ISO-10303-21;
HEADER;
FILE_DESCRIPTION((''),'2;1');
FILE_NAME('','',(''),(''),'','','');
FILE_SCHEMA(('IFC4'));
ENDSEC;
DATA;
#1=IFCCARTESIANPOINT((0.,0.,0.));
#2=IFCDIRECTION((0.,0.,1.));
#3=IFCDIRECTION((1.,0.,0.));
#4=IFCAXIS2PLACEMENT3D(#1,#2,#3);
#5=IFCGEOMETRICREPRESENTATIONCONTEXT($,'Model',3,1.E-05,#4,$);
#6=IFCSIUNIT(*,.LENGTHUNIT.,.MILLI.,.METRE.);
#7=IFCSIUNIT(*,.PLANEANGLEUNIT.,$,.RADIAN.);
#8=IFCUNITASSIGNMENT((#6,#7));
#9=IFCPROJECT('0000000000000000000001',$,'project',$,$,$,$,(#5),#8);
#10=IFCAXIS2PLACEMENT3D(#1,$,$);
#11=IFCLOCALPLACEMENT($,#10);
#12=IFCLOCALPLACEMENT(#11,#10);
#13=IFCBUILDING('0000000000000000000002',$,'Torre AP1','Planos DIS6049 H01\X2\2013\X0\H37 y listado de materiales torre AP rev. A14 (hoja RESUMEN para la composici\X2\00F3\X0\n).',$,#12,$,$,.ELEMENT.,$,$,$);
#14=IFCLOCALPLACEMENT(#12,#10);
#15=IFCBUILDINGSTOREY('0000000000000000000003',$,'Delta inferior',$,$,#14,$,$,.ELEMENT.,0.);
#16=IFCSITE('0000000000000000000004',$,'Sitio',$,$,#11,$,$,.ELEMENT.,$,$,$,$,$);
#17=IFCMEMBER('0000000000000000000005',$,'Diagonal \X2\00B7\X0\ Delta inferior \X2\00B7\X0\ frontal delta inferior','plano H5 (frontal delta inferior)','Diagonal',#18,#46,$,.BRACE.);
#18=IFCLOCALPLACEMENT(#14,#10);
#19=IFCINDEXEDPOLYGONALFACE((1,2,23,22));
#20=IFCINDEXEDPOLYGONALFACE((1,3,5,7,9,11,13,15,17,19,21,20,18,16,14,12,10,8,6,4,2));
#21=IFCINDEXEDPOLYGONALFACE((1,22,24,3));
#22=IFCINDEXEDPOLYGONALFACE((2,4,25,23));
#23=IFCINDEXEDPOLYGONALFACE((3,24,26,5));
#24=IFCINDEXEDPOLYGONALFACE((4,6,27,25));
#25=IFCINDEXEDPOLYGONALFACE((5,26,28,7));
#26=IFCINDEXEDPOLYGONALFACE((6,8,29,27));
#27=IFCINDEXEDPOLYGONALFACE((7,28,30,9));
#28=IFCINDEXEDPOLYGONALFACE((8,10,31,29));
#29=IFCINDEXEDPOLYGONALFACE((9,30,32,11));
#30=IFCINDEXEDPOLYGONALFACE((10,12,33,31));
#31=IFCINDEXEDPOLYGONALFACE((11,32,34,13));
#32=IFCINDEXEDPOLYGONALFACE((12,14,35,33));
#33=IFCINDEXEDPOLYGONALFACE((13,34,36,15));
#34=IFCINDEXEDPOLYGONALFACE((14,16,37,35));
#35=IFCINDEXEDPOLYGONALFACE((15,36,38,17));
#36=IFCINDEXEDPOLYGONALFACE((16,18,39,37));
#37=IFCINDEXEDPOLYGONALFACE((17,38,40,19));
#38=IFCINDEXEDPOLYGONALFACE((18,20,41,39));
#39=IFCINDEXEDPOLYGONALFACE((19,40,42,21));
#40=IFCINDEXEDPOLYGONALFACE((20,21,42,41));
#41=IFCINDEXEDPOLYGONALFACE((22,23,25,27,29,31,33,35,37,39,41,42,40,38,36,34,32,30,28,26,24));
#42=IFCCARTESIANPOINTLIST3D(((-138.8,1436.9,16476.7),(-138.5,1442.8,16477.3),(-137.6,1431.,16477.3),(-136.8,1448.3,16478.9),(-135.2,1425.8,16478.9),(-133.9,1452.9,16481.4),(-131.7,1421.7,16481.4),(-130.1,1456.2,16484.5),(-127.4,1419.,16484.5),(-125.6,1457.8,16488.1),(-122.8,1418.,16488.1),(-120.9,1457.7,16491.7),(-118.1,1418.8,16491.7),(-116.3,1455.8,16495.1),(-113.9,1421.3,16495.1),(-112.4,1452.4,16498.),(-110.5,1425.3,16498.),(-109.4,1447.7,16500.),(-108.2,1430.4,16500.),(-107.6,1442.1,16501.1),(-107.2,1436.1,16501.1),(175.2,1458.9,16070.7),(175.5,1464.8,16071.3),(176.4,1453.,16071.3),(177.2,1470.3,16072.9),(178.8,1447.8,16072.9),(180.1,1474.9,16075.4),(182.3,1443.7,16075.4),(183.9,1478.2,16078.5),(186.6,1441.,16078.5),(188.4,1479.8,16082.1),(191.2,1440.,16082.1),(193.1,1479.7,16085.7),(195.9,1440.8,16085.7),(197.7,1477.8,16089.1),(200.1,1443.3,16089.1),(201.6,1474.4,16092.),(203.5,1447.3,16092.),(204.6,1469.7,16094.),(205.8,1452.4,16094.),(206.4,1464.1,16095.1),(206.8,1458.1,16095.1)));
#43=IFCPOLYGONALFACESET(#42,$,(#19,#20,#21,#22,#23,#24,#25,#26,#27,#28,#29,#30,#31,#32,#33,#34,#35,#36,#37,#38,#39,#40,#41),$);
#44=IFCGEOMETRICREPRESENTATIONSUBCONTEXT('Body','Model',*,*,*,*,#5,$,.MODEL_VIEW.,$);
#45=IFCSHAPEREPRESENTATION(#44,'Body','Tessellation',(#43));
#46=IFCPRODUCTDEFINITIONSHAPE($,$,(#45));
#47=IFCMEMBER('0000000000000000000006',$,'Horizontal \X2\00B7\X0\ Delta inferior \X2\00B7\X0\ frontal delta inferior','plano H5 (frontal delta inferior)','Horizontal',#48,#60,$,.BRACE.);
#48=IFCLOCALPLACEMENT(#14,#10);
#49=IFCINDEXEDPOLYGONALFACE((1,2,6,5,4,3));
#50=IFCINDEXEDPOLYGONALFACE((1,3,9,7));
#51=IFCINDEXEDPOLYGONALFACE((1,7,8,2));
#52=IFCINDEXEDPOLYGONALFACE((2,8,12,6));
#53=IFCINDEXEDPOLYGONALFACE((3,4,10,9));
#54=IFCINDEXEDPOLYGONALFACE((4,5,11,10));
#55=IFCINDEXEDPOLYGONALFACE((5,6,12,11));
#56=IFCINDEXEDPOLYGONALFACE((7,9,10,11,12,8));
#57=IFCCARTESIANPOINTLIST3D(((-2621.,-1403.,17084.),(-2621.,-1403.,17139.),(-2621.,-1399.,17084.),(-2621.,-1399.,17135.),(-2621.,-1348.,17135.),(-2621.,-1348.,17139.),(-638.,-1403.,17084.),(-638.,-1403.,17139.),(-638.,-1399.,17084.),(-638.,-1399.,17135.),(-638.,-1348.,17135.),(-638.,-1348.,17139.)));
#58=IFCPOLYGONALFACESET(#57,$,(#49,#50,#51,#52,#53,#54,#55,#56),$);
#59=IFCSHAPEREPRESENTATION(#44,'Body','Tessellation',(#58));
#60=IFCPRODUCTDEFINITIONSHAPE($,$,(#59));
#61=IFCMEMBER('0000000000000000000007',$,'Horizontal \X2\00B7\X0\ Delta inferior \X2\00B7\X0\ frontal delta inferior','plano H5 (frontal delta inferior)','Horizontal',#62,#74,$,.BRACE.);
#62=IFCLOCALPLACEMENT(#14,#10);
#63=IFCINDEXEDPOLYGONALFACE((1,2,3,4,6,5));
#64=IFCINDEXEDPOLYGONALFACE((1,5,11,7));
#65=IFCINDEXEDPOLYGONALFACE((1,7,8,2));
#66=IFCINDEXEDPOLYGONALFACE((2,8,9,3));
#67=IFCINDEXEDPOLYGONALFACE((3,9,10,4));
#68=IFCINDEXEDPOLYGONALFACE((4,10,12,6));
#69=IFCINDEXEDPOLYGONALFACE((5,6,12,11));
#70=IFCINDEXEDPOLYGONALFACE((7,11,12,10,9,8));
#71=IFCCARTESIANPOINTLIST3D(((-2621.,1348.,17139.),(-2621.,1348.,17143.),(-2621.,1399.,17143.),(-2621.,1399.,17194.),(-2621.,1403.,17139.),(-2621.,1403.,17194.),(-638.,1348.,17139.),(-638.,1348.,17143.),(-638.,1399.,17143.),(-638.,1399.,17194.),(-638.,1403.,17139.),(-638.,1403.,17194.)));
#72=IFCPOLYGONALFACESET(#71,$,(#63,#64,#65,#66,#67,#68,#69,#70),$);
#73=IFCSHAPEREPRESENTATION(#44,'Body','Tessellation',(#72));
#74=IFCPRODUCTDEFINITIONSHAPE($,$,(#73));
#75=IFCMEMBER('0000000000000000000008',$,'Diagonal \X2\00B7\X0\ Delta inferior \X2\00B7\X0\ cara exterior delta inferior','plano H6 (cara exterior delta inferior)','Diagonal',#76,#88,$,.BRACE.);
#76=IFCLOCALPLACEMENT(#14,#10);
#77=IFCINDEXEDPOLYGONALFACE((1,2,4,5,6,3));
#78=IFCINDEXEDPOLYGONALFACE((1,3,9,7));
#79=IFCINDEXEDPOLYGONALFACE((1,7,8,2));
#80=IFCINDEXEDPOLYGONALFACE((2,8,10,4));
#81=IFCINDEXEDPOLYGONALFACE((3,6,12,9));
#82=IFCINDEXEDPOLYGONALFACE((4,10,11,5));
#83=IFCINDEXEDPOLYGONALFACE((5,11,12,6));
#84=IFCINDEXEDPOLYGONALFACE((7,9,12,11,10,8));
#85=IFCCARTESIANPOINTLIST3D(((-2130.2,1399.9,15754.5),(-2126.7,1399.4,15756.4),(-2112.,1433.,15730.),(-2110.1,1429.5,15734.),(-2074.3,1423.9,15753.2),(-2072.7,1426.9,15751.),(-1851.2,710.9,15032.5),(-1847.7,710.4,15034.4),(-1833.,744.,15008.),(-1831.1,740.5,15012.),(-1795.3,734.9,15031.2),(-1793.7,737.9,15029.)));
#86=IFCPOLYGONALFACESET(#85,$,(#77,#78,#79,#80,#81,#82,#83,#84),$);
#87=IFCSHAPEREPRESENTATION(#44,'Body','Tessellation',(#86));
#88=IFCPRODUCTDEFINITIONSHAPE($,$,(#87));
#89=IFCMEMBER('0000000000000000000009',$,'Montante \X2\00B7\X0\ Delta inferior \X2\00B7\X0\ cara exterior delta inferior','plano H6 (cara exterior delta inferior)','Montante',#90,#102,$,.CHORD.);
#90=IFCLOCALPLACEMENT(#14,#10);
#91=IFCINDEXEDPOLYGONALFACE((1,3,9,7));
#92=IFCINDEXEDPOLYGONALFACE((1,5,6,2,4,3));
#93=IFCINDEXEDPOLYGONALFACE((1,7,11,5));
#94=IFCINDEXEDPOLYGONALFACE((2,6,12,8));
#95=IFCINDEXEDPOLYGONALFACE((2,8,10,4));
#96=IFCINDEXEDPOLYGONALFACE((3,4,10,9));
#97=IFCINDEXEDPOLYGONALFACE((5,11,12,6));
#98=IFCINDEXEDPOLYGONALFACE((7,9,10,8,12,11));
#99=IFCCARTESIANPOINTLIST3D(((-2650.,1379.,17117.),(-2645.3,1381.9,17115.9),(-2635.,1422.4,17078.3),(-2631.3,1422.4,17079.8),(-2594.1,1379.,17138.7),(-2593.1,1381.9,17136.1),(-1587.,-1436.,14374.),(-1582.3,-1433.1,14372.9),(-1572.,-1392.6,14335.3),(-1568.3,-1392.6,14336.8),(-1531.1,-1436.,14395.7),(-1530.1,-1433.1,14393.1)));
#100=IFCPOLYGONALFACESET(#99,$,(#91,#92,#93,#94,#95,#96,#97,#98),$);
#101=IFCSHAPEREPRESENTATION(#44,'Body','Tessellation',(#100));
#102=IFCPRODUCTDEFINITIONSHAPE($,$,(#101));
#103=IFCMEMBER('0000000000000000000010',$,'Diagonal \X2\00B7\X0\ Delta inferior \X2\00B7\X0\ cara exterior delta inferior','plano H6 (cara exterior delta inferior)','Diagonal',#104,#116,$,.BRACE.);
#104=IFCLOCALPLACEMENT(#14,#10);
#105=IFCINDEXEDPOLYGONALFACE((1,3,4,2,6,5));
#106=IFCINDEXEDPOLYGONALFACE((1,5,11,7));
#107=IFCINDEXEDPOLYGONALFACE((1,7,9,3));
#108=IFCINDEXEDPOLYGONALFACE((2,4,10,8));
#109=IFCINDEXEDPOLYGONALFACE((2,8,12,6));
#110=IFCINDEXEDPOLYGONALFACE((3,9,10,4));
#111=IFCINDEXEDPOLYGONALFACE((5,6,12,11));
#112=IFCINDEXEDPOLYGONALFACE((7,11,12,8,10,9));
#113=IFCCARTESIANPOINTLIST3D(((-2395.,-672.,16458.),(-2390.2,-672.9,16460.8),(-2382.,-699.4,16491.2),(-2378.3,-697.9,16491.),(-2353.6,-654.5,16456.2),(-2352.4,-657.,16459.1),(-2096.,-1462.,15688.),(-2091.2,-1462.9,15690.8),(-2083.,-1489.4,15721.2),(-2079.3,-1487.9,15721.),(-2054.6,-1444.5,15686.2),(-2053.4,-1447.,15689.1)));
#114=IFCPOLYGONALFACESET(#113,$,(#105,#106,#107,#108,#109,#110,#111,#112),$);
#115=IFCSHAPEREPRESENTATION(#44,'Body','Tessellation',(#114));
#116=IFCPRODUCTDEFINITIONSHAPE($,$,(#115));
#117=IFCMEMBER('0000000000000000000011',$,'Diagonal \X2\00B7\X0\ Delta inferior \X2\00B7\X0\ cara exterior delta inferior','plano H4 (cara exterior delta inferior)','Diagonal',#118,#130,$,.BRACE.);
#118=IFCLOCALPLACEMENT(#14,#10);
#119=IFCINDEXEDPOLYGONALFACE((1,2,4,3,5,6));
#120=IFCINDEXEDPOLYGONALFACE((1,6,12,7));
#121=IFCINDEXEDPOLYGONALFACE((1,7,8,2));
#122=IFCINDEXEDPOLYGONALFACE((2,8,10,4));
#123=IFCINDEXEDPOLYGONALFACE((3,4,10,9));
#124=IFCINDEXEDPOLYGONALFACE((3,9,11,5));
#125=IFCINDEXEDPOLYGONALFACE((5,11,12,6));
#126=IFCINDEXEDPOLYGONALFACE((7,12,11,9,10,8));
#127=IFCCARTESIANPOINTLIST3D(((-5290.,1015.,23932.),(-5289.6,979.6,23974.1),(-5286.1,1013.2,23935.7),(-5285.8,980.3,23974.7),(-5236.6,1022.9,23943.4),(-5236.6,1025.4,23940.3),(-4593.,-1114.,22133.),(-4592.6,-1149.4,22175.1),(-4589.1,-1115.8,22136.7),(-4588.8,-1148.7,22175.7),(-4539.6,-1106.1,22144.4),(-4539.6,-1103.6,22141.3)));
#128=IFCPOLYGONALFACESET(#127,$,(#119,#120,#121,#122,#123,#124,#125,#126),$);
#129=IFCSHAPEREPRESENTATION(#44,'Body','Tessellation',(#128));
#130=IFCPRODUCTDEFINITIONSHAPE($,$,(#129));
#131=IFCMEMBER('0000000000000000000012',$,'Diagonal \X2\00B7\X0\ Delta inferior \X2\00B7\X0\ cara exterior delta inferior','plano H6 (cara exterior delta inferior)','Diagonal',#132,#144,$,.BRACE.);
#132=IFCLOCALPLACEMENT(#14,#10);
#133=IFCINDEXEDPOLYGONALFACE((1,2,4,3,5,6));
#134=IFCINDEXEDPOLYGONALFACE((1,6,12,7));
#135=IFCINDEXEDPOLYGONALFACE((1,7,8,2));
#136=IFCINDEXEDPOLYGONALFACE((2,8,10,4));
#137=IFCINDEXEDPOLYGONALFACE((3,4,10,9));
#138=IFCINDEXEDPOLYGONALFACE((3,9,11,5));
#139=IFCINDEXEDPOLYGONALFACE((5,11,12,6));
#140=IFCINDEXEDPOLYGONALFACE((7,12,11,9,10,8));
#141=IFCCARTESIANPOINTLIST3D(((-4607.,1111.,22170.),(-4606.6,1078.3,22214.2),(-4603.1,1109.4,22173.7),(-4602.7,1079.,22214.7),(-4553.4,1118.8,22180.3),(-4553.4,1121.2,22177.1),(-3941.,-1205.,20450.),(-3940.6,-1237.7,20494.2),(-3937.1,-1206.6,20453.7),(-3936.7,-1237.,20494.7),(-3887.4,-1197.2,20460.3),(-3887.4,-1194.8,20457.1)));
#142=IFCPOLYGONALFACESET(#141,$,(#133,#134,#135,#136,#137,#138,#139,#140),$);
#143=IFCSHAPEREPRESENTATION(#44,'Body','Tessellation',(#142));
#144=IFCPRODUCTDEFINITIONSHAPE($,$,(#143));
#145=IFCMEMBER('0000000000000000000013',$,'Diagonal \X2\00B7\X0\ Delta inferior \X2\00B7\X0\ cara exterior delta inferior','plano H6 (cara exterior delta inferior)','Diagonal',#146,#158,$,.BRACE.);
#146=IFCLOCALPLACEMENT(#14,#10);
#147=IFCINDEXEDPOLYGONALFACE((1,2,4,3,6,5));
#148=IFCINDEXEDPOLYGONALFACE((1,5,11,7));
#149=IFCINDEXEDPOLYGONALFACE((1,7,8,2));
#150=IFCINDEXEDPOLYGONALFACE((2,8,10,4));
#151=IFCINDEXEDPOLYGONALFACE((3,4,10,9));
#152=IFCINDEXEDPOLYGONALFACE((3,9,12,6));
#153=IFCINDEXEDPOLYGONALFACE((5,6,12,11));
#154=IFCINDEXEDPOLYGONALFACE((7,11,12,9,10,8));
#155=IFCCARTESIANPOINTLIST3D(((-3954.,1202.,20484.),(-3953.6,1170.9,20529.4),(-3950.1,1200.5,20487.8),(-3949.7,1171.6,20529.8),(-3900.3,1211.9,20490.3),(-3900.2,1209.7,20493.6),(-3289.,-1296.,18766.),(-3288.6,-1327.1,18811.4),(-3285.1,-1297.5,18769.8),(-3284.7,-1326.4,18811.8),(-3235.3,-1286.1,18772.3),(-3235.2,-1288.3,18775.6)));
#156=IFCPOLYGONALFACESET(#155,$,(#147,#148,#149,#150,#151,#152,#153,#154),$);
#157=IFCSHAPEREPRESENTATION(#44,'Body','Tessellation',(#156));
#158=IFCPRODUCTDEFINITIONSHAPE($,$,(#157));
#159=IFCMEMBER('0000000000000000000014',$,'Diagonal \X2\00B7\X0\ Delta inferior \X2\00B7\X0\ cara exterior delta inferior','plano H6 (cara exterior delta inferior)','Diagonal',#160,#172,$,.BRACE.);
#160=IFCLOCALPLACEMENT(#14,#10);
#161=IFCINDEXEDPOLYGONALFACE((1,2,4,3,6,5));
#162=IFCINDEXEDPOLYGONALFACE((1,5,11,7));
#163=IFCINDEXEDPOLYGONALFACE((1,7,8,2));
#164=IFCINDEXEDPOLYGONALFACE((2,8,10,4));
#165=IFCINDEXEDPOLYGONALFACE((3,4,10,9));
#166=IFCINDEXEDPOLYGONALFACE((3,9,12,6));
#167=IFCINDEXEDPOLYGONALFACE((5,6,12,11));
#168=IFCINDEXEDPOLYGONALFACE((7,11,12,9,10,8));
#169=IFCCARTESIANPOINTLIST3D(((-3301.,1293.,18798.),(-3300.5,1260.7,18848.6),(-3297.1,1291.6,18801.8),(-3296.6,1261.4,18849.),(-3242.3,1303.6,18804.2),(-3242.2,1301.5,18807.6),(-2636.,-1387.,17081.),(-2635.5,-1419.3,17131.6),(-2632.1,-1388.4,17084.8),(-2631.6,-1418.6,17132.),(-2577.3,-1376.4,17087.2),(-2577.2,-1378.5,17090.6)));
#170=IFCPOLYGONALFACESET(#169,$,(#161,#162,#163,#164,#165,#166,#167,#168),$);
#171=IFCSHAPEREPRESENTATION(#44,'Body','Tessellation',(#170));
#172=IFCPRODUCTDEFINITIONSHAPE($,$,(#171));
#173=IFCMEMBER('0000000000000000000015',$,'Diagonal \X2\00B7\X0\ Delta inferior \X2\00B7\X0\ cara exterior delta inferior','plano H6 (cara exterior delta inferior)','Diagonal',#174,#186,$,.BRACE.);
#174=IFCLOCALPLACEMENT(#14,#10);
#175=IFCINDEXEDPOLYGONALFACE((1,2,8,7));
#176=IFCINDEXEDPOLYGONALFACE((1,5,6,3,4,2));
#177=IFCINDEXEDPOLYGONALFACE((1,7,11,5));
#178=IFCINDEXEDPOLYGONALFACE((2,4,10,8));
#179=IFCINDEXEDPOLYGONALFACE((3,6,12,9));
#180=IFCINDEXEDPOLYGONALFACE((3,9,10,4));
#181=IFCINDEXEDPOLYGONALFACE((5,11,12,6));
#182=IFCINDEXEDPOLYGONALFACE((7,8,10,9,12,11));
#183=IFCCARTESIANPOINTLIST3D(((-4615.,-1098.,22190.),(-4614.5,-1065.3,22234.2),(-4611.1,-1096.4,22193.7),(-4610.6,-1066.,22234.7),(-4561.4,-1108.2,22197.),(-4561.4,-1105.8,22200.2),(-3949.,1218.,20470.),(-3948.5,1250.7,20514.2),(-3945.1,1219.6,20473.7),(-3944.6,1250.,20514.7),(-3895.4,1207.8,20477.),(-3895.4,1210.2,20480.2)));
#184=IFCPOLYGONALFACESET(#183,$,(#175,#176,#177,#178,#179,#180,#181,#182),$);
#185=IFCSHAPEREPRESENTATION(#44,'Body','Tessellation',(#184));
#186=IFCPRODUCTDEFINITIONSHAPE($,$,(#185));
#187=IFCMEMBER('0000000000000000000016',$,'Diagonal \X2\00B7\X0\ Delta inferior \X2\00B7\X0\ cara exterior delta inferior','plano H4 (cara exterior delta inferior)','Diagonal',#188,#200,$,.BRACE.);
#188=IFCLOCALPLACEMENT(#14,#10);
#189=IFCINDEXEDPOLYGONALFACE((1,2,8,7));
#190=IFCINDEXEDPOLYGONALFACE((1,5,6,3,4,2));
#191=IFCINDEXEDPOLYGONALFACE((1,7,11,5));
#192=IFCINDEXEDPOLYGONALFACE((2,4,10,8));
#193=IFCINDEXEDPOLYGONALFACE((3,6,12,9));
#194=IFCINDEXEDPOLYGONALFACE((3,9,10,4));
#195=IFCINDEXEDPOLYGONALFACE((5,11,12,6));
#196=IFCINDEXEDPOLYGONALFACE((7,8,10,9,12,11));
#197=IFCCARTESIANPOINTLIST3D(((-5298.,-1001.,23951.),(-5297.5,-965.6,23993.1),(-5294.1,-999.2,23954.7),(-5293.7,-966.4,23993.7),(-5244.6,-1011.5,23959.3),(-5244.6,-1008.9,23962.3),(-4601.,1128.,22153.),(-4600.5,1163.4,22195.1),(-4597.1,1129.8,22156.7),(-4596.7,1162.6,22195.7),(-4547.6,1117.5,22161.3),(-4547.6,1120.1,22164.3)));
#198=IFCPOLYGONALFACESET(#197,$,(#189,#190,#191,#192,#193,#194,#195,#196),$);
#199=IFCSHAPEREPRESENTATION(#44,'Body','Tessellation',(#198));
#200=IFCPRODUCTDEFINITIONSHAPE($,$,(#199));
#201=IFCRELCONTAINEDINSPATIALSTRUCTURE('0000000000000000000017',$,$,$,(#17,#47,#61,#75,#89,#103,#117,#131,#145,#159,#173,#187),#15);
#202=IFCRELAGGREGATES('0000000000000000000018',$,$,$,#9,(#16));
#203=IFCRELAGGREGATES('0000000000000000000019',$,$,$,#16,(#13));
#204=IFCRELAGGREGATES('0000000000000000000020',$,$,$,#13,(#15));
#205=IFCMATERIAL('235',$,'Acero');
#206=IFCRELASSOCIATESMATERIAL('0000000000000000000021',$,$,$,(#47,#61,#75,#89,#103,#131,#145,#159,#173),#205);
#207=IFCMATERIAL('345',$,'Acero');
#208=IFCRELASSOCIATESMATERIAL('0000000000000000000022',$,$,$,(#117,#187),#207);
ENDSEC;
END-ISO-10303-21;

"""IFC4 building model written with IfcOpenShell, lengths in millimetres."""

from ifc_helpers import new_model, si_unit, frame, frame_2d, origin, origin_with_axes, place, context, subcontext, project, spatial, circle, l_section, extrude, material, element, save


model = new_model("IFC4")

# Units and contexts
model_context = context("Model", 3, precision=1e-05, world=origin_with_axes())
body_context = subcontext(model_context, "Body", "Model", "MODEL_VIEW")
ifc_project = project(units=[si_unit("LENGTHUNIT", "METRE", prefix="MILLI"), si_unit("PLANEANGLEUNIT", "RADIAN")], contexts=[model_context])

# Site, building, storey
site_placement = place(None, origin())
site = spatial("IfcSite", under=ifc_project, at=site_placement, Name="Sitio", CompositionType="ELEMENT")
building_placement = place(site_placement, origin())
building = spatial("IfcBuilding", under=site, at=building_placement, Name="Torre AP1", Description="Planos DIS6049 H01–H37 y listado de materiales torre AP rev. A14 (hoja RESUMEN para la composición).", CompositionType="ELEMENT")
storey_placement = place(building_placement, origin())
storey = spatial("IfcBuildingStorey", under=building, at=storey_placement, Name="Delta inferior", CompositionType="ELEMENT", Elevation=0.0)

# Members
ifc_material_1 = material(Name="235", Category="Acero")
for number, where, z_axis, x_axis, name in (
    (1, (191.0, 1460.0, 16083.0), (-0.611219, -0.042824, 0.790302), (0.011492, -0.99891, -0.04524), "Diagonal · Delta inferior · frontal delta inferior"),
):
    element("IfcMember", number, at=place(storey_placement, frame(where, z_axis=z_axis, x_axis=x_axis)), inside=storey, Name=name, Description="plano H5 (frontal delta inferior)", ObjectType="Diagonal", PredefinedType="BRACE", context=body_context, shape_type="SweptSolid", body=[
        extrude(circle(Radius=20.0), None, (0.0, 0.0, 1.0), 513.7),
    ])
for number, where, z_axis, x_axis, name in (
    (2, (-638.0, -1403.0, 17139.0), (-1.0, 0.0, 0.0), (0.0, 1.0, 0.0), "Horizontal · Delta inferior · frontal delta inferior"),
    (3, (-638.0, 1403.0, 17139.0), (-1.0, 0.0, 0.0), (0.0, -1.0, 0.0), "Horizontal · Delta inferior · frontal delta inferior"),
):
    element("IfcMember", number, at=place(storey_placement, frame(where, z_axis=z_axis, x_axis=x_axis)), inside=storey, material=ifc_material_1, Name=name, Description="plano H5 (frontal delta inferior)", ObjectType="Horizontal", PredefinedType="BRACE", context=body_context, shape_type="SweptSolid", body=[
        extrude(l_section(Depth=55.0, Width=55.0, Thickness=4.0, at=frame_2d((27.5, 27.5))), None, (0.0, 0.0, 1.0), 1983.0),
    ])
member_1_placement = place(storey_placement, frame((-2112.0, 1433.0, 15730.0), z_axis=(0.269236, -0.664888, -0.696733), x_axis=(0.873631, -0.135855, 0.46724)))
element("IfcMember", 4, at=member_1_placement, inside=storey, material=ifc_material_1, Name="Diagonal · Delta inferior · cara exterior delta inferior", Description="plano H6 (cara exterior delta inferior)", ObjectType="Diagonal", PredefinedType="BRACE", context=body_context, shape_type="SweptSolid", body=[
    extrude(l_section(Depth=45.0, Width=45.0, Thickness=4.0, at=frame_2d((22.5, 22.5))), None, (0.0, 0.0, 1.0), 1036.3),
])
member_2_placement = place(storey_placement, frame((-2650.0, 1379.0, 17117.0), z_axis=(0.261074, -0.691368, -0.673685), x_axis=(0.249824, 0.722503, -0.644653)))
element("IfcMember", 5, at=member_2_placement, inside=storey, material=ifc_material_1, Name="Montante · Delta inferior · cara exterior delta inferior", Description="plano H6 (cara exterior delta inferior)", ObjectType="Montante", PredefinedType="CHORD", context=body_context, shape_type="SweptSolid", body=[
    extrude(l_section(Depth=60.0, Width=60.0, Thickness=4.0, at=frame_2d((30.0, 30.0))), None, (0.0, 0.0, 1.0), 4071.6),
])
member_3_placement = place(storey_placement, frame((-2395.0, -672.0, 16458.0), z_axis=(0.261597, -0.691176, -0.673678), x_axis=(0.920687, 0.38817, -0.040739)))
element("IfcMember", 6, at=member_3_placement, inside=storey, material=ifc_material_1, Name="Diagonal · Delta inferior · cara exterior delta inferior", Description="plano H6 (cara exterior delta inferior)", ObjectType="Diagonal", PredefinedType="BRACE", context=body_context, shape_type="SweptSolid", body=[
    extrude(l_section(Depth=45.0, Width=45.0, Thickness=4.0, at=frame_2d((22.5, 22.5))), None, (0.0, 0.0, 1.0), 1143.0),
])
ifc_material_2 = material(Name="345", Category="Acero")
member_4_placement = place(storey_placement, frame((-5290.0, 1015.0, 23932.0), z_axis=(0.242593, -0.741005, -0.626147), x_axis=(0.970107, 0.189587, 0.151492)))
element("IfcMember", 7, at=member_4_placement, inside=storey, material=ifc_material_2, Name="Diagonal · Delta inferior · cara exterior delta inferior", Description="plano H4 (cara exterior delta inferior)", ObjectType="Diagonal", PredefinedType="BRACE", context=body_context, shape_type="SweptSolid", body=[
    extrude(l_section(Depth=55.0, Width=55.0, Thickness=4.0, at=frame_2d((27.5, 27.5))), None, (0.0, 0.0, 1.0), 2873.1),
])
member_5_placement = place(storey_placement, frame((-4607.0, 1111.0, 22170.0), z_axis=(0.224946, -0.782244, -0.580941), x_axis=(0.974349, 0.184591, 0.128724)))
element("IfcMember", 8, at=member_5_placement, inside=storey, material=ifc_material_1, Name="Diagonal · Delta inferior · cara exterior delta inferior", Description="plano H6 (cara exterior delta inferior)", ObjectType="Diagonal", PredefinedType="BRACE", context=body_context, shape_type="SweptSolid", body=[
    extrude(l_section(Depth=55.0, Width=55.0, Thickness=4.0, at=frame_2d((27.5, 27.5))), None, (0.0, 0.0, 1.0), 2960.7),
])
member_6_placement = place(storey_placement, frame((-3954.0, 1202.0, 20484.0), z_axis=(0.214252, -0.804812, -0.55351), x_axis=(0.976751, 0.180783, 0.115217)))
element("IfcMember", 9, at=member_6_placement, inside=storey, material=ifc_material_1, Name="Diagonal · Delta inferior · cara exterior delta inferior", Description="plano H6 (cara exterior delta inferior)", ObjectType="Diagonal", PredefinedType="BRACE", context=body_context, shape_type="SweptSolid", body=[
    extrude(l_section(Depth=55.0, Width=55.0, Thickness=4.0, at=frame_2d((27.5, 27.5))), None, (0.0, 0.0, 1.0), 3103.8),
])
member_7_placement = place(storey_placement, frame((-3301.0, 1293.0, 18798.0), z_axis=(0.204517, -0.824217, -0.528052), x_axis=(0.978826, 0.176893, 0.102997)))
element("IfcMember", 10, at=member_7_placement, inside=storey, material=ifc_material_1, Name="Diagonal · Delta inferior · cara exterior delta inferior", Description="plano H6 (cara exterior delta inferior)", ObjectType="Diagonal", PredefinedType="BRACE", context=body_context, shape_type="SweptSolid", body=[
    extrude(l_section(Depth=60.0, Width=60.0, Thickness=4.0, at=frame_2d((30.0, 30.0))), None, (0.0, 0.0, 1.0), 3251.6),
])
member_8_placement = place(storey_placement, frame((-3949.0, 1218.0, 20470.0), z_axis=(-0.224946, -0.782244, 0.580941), x_axis=(0.974336, -0.185683, 0.127247)))
element("IfcMember", 11, at=member_8_placement, inside=storey, material=ifc_material_1, Name="Diagonal · Delta inferior · cara exterior delta inferior", Description="plano H6 (cara exterior delta inferior)", ObjectType="Diagonal", PredefinedType="BRACE", context=body_context, shape_type="SweptSolid", body=[
    extrude(l_section(Depth=55.0, Width=55.0, Thickness=4.0, at=frame_2d((27.5, 27.5))), None, (0.0, 0.0, 1.0), 2960.7),
])
member_9_placement = place(storey_placement, frame((-4601.0, 1128.0, 22153.0), z_axis=(-0.242646, -0.741166, 0.625936), x_axis=(0.97008, -0.190866, 0.150051)))
element("IfcMember", 12, at=member_9_placement, inside=storey, material=ifc_material_2, Name="Diagonal · Delta inferior · cara exterior delta inferior", Description="plano H4 (cara exterior delta inferior)", ObjectType="Diagonal", PredefinedType="BRACE", context=body_context, shape_type="SweptSolid", body=[
    extrude(l_section(Depth=55.0, Width=55.0, Thickness=4.0, at=frame_2d((27.5, 27.5))), None, (0.0, 0.0, 1.0), 2872.5),
])

save(model, "model.ifc")
